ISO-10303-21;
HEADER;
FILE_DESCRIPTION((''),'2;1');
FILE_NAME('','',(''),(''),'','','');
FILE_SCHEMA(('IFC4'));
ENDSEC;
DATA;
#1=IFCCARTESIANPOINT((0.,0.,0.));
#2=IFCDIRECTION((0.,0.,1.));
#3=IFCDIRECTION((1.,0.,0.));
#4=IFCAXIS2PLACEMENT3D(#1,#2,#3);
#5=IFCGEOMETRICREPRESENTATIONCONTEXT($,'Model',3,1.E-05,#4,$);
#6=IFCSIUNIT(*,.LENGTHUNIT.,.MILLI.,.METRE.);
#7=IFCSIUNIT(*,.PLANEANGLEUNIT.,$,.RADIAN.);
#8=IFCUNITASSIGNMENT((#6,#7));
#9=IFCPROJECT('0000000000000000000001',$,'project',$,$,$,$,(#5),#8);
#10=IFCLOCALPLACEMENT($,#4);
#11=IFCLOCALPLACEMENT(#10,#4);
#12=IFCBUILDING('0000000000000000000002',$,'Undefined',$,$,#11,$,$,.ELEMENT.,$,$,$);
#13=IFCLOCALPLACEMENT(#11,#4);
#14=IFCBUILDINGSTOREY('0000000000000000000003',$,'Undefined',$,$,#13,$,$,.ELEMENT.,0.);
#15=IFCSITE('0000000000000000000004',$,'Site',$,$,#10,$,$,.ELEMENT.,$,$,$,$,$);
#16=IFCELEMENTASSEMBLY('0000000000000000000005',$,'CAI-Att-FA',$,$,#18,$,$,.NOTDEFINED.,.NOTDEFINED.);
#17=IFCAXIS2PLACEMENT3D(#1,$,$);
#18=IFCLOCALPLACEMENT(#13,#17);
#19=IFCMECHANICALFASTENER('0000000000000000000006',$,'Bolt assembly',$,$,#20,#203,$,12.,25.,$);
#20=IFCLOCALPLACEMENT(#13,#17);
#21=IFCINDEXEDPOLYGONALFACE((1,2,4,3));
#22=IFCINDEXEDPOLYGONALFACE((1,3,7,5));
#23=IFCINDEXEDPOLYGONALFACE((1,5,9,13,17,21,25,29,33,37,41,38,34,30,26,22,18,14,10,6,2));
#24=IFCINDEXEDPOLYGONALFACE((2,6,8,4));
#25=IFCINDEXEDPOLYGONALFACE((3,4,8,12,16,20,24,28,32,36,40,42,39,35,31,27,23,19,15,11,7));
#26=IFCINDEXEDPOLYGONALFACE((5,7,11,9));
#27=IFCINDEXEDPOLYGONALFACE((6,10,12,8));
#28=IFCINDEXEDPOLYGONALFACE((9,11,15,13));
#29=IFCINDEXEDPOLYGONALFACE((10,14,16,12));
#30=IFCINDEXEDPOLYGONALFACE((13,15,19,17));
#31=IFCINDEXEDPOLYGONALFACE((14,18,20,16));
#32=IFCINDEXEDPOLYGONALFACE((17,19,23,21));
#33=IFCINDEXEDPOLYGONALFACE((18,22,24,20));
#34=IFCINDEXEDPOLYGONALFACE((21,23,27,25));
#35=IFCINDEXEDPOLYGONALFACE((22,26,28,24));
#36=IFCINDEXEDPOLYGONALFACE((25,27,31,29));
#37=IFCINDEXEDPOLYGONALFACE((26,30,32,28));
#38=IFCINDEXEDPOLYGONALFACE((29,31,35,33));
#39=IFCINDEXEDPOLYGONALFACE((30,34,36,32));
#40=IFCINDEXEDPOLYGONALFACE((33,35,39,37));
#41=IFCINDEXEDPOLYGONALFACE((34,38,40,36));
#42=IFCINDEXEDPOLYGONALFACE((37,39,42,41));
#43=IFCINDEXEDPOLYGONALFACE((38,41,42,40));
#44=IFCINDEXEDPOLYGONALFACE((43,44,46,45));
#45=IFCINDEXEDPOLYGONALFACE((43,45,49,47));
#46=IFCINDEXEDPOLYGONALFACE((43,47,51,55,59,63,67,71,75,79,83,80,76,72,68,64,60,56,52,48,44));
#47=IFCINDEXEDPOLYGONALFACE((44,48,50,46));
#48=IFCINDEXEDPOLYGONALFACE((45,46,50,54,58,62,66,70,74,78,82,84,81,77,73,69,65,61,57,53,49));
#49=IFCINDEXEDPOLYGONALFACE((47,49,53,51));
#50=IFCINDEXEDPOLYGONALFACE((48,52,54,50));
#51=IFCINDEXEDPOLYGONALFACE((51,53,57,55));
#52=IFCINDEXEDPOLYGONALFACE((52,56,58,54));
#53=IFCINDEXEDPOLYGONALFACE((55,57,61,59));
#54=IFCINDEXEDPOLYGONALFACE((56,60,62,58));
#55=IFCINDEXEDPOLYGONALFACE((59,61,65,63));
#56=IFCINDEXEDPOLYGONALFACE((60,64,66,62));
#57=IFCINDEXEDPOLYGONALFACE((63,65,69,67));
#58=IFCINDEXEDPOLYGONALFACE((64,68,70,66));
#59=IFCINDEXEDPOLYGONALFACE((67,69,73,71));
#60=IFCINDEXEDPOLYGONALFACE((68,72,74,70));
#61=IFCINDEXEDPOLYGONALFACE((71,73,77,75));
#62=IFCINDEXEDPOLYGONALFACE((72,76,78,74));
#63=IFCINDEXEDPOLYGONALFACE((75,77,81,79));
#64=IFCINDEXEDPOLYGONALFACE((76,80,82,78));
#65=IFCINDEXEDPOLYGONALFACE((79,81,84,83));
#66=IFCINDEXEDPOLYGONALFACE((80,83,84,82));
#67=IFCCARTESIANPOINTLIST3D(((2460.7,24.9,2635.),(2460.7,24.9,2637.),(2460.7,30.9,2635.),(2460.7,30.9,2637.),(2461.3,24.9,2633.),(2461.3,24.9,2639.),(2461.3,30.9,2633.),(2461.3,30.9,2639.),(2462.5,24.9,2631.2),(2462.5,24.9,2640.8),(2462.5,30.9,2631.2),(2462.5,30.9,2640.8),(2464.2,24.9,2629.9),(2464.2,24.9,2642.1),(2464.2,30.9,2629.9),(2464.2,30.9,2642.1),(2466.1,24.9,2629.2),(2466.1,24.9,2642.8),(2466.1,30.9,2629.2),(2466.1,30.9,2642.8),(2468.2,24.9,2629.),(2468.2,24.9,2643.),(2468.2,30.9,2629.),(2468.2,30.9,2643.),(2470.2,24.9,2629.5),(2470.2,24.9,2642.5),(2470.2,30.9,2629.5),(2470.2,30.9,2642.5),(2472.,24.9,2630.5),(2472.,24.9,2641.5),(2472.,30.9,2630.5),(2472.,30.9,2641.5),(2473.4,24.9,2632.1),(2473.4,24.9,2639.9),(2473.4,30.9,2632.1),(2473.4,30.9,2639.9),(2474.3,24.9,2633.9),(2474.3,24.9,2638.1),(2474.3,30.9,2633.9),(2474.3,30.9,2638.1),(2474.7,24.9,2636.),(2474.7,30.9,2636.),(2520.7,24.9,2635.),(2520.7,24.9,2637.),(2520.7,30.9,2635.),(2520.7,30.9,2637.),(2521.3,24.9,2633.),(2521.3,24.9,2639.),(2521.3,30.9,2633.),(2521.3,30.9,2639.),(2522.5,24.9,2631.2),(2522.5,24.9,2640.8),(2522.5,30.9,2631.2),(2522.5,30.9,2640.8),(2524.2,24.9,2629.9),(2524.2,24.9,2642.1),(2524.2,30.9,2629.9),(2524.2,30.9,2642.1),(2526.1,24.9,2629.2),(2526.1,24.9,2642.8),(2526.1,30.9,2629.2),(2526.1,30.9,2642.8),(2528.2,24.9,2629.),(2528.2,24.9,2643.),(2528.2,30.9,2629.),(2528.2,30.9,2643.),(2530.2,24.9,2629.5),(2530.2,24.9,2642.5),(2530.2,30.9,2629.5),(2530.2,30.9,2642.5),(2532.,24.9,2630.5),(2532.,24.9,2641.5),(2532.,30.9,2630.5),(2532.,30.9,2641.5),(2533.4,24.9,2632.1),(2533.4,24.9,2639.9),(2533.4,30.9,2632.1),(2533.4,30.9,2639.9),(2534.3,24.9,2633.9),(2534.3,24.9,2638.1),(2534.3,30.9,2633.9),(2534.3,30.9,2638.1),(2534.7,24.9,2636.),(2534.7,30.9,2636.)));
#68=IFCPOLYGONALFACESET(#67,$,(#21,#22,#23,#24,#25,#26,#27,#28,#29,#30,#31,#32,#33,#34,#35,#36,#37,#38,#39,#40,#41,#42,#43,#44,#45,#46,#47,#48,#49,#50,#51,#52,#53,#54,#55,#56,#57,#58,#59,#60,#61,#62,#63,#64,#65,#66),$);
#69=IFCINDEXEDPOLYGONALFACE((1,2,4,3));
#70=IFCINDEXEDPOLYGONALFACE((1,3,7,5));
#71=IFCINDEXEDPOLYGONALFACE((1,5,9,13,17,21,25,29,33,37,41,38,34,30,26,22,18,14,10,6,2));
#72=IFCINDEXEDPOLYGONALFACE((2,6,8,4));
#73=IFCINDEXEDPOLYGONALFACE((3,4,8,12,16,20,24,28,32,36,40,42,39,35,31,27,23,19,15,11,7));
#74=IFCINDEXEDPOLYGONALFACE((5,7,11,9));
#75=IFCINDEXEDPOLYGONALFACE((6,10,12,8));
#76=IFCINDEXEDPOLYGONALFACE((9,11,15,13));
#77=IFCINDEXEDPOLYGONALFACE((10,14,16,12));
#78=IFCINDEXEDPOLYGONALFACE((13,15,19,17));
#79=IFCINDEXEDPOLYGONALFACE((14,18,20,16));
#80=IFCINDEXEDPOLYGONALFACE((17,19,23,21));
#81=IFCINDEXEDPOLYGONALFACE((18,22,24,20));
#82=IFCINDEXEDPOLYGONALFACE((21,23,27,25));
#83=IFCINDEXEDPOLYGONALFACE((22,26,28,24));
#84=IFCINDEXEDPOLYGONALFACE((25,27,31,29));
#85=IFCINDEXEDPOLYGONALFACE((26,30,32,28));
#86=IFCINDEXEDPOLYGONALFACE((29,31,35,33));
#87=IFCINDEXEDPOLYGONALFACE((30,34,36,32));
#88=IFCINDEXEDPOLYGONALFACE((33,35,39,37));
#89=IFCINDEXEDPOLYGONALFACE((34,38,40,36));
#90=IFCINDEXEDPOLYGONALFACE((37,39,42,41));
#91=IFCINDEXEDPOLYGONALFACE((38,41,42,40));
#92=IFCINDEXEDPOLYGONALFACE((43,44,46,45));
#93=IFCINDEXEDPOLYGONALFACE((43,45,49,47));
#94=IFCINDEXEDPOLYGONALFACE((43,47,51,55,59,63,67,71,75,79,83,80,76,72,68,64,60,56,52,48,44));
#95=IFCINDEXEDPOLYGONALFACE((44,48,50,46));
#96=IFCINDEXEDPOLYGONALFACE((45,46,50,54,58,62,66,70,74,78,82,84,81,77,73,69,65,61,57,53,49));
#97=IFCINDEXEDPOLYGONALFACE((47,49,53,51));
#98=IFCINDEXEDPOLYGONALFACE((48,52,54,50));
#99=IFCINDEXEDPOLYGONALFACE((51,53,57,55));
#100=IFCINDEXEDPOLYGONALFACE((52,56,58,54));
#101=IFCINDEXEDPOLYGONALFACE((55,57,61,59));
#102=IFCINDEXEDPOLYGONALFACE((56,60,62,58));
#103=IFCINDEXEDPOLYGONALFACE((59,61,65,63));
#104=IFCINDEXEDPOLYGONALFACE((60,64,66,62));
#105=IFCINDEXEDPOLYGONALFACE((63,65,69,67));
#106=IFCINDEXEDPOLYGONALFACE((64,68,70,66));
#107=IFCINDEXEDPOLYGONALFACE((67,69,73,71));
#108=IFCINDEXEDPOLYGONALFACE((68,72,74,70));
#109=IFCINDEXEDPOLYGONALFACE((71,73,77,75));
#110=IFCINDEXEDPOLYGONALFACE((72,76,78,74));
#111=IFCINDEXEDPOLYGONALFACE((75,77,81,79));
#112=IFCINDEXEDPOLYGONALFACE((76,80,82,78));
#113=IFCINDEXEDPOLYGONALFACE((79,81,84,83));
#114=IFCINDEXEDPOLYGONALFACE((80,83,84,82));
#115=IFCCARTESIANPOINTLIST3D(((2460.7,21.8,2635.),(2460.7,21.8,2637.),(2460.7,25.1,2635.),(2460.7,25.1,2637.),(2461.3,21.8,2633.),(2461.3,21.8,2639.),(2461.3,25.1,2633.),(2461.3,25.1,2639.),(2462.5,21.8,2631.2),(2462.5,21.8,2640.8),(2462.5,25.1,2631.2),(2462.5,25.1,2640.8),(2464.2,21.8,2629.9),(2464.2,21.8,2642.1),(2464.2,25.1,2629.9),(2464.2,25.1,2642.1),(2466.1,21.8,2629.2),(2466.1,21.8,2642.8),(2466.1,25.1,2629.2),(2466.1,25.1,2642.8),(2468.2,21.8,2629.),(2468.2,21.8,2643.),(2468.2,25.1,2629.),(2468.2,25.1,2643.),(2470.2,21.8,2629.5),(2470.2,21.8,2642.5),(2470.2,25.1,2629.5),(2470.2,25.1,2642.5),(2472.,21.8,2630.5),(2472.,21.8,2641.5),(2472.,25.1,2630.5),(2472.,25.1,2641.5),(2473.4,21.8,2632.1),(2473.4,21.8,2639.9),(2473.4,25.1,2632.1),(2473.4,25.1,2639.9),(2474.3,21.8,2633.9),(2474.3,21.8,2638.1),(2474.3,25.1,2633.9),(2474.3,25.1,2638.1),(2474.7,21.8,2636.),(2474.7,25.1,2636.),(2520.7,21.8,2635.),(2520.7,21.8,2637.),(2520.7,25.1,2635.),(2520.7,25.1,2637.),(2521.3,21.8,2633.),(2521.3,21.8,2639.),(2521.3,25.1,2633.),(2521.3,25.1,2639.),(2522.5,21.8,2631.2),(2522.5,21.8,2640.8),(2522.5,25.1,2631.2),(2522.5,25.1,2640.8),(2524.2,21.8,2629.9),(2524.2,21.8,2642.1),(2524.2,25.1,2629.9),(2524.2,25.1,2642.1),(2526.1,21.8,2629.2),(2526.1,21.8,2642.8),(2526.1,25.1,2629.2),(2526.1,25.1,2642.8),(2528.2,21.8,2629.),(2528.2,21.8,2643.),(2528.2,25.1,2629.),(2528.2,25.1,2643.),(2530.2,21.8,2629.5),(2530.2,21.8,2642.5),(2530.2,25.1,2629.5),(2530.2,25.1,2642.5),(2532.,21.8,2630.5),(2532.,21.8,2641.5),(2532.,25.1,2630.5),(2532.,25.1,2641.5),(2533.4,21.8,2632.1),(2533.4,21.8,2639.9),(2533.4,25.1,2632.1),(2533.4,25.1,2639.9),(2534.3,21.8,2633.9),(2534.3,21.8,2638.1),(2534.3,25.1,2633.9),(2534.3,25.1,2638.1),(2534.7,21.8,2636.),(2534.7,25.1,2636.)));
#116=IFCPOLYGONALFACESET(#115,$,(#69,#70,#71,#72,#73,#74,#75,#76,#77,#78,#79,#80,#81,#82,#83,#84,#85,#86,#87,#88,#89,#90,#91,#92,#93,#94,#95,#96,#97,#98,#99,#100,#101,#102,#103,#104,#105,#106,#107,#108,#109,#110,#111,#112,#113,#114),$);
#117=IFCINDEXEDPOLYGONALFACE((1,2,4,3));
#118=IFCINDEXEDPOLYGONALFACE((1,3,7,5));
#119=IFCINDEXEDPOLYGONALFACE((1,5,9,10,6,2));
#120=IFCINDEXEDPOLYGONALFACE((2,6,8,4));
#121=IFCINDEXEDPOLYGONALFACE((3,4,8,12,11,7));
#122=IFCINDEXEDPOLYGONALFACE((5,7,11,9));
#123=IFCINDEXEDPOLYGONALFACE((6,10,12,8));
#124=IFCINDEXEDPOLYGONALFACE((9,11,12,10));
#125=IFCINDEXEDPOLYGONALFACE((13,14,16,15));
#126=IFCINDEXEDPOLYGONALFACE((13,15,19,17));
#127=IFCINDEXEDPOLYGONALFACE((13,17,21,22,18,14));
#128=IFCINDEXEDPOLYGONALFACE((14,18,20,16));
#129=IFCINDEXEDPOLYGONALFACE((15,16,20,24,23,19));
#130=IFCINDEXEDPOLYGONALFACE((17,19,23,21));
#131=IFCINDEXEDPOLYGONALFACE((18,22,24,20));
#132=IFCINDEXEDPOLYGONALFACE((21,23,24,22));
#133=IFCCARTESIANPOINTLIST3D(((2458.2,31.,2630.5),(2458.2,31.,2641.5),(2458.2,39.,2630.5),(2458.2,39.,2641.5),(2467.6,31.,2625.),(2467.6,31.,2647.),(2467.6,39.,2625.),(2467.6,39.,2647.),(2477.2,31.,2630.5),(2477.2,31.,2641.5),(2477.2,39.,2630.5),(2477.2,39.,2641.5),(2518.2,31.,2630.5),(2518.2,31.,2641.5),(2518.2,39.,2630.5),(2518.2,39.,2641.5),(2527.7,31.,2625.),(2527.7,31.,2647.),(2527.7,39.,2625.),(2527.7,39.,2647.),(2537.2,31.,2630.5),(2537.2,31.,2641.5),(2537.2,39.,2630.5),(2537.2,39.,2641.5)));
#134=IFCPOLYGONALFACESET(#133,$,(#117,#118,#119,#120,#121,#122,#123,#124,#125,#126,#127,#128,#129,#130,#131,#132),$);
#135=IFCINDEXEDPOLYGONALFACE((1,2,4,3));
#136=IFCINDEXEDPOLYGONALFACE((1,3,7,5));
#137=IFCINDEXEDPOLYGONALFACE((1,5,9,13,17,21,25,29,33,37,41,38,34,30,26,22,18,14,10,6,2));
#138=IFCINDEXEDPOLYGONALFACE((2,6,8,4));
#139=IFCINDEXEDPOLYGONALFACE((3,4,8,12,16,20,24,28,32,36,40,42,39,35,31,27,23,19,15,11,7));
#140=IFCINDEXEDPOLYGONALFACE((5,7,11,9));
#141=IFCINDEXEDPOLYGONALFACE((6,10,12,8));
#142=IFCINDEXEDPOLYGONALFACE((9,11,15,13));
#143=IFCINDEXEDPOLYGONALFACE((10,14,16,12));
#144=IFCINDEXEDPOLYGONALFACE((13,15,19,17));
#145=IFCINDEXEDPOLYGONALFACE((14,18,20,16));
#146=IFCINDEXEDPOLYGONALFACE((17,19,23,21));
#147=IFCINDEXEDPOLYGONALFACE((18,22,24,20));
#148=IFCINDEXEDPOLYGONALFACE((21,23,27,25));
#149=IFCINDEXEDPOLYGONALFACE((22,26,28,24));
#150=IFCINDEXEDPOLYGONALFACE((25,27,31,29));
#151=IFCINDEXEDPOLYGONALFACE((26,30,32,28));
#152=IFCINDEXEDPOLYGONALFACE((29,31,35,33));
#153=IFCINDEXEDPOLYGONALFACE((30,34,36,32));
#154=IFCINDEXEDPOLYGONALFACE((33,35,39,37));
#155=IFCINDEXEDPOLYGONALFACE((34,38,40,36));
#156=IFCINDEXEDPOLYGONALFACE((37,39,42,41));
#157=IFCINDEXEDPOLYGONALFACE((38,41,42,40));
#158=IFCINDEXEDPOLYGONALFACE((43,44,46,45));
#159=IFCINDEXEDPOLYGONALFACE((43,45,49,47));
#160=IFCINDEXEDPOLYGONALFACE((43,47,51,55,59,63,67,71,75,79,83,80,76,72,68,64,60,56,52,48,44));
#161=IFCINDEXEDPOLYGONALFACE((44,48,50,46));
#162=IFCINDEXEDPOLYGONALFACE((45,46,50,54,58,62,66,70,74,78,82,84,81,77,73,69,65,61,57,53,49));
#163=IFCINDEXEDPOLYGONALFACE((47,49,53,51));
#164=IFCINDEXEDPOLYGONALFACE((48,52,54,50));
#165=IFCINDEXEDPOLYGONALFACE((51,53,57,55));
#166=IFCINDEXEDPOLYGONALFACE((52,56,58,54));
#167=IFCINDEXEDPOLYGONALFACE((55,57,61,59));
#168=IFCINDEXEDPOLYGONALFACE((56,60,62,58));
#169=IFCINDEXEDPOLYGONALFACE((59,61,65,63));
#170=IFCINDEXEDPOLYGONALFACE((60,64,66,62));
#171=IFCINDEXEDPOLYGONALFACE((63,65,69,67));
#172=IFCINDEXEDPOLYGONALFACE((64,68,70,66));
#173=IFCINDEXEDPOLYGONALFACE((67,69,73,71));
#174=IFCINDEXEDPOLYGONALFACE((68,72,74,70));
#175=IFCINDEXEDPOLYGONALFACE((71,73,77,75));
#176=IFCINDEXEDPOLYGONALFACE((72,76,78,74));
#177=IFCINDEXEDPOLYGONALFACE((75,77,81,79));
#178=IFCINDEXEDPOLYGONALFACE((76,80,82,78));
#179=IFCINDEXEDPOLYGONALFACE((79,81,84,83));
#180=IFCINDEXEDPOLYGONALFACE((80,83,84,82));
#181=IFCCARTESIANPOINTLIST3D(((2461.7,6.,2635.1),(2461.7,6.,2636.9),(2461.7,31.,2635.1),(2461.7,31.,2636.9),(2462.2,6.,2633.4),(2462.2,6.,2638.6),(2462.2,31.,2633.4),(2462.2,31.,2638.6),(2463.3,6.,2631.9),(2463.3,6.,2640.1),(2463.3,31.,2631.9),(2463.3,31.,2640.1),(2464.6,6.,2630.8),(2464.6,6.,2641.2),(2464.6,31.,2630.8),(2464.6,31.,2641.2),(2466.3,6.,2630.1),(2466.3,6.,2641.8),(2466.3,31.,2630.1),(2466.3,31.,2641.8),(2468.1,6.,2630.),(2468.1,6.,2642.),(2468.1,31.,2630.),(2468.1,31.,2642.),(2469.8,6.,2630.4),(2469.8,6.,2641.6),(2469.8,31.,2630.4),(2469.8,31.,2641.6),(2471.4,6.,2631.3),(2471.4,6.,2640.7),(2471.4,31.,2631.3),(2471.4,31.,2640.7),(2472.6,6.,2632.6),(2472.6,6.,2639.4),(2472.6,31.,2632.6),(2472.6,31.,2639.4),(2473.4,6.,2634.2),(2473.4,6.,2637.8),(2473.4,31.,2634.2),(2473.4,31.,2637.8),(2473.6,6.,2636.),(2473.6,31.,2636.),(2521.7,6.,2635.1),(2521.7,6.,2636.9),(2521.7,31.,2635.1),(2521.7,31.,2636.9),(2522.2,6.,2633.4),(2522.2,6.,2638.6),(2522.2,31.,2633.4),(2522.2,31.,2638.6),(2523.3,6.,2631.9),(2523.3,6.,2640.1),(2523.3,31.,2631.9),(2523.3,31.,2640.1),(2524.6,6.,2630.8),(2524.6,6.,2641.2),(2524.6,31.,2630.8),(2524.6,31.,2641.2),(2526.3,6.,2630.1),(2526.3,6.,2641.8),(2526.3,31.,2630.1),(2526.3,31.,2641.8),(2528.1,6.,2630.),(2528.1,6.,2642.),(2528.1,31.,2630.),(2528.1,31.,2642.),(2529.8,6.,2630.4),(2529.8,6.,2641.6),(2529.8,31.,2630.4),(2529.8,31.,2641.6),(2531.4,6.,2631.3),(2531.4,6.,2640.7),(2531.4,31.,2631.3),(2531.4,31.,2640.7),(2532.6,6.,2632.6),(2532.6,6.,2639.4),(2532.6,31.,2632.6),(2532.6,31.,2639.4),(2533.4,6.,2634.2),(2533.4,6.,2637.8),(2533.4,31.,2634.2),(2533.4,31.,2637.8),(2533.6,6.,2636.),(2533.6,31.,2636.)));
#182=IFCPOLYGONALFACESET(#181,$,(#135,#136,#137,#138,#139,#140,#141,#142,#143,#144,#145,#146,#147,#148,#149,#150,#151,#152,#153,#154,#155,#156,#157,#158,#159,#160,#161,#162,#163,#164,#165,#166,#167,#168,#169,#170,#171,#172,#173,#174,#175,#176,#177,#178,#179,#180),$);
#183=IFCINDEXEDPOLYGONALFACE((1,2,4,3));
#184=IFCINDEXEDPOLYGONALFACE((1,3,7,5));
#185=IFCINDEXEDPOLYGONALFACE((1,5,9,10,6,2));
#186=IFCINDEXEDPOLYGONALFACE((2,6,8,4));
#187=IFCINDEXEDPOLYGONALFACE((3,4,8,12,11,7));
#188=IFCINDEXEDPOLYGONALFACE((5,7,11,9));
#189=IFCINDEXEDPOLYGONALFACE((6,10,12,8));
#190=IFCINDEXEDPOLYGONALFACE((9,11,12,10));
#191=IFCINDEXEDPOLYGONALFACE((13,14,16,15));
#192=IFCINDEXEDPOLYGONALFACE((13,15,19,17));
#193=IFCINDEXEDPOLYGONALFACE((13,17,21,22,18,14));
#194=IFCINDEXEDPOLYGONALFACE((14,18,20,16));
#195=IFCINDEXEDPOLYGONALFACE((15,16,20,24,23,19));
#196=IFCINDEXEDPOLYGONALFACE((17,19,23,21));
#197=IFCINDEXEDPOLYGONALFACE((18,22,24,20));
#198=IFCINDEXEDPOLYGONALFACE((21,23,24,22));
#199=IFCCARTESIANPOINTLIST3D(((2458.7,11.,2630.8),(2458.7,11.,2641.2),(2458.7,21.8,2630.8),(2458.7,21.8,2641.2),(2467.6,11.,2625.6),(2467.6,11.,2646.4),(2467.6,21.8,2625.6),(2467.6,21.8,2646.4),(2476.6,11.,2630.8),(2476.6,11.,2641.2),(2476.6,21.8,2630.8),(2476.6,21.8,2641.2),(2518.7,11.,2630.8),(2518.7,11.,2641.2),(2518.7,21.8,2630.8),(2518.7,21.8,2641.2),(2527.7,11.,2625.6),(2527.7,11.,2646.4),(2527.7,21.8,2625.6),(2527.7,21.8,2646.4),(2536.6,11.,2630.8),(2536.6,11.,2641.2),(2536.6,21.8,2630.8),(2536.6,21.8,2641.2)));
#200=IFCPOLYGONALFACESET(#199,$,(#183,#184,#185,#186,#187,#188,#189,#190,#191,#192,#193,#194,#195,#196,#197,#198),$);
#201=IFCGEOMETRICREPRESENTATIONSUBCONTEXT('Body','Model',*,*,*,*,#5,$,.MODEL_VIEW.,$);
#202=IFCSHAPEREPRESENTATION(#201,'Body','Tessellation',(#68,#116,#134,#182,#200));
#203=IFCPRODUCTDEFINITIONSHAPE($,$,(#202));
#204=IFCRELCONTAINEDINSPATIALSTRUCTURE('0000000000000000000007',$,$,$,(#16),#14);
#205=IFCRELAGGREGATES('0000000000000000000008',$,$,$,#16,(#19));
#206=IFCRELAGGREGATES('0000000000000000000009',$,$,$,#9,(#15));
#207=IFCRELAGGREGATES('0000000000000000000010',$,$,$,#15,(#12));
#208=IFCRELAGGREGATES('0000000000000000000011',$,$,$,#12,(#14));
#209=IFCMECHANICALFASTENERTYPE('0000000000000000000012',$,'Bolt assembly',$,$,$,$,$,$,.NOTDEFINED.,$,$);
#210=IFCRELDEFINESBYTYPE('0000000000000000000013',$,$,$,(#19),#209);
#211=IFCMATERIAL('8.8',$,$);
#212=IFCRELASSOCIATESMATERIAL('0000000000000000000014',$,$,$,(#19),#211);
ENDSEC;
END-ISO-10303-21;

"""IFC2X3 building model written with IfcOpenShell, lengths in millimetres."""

from ifc_helpers import new_model, si_unit, frame, origin_with_axes, origin_2d_with_axis, place, context, subcontext, project, spatial, polyline, circle, outline, extrude, source, transform, mapped, material, type_object, element, aggregate, save


model = new_model("IFC2X3")

# Units and contexts
model_context = context("Model", 3, precision=1e-05, world=origin_with_axes())
body_context = subcontext(model_context, "Body", "Model", "MODEL_VIEW")
ifc_project = project(units=[si_unit("LENGTHUNIT", "METRE", prefix="MILLI"), si_unit("PLANEANGLEUNIT", "RADIAN")], contexts=[model_context])

# Site, building, storey
site_placement = place(None, origin_with_axes())
site = spatial("IfcSite", under=ifc_project, at=site_placement, Name="Site", CompositionType="ELEMENT")
building_placement = place(site_placement, origin_with_axes())
building = spatial("IfcBuilding", under=site, at=building_placement, Name="Undefined", CompositionType="ELEMENT")
storey_placement = place(building_placement, origin_with_axes())
storey = spatial("IfcBuildingStorey", under=building, at=storey_placement, Name="Undefined", CompositionType="ELEMENT", Elevation=0.0)

# Shared definitions
mechanical_fastener_type = type_object("IfcMechanicalFastenerType", Name="Bolt assembly")

# Element assembly, mechanical fastener
assembly_1_placement = place(storey_placement, origin_with_axes())
assembly_1 = element("IfcElementAssembly", 1, at=assembly_1_placement, inside=storey, Name="CAI-Att-FA", AssemblyPlace="NOTDEFINED", PredefinedType="NOTDEFINED")
ifc_material_1 = material(Name="8.8")
shared_shape_1 = source(origin_with_axes(), body_context, "Body", "SweptSolid", [
    extrude(circle(Radius=7.0, at=origin_2d_with_axis()), frame((0.0, -5.9, 0.0), z_axis=(0.0, 1.0, 0.0), x_axis=(1.0, 0.0, 0.0)), (0.0, 0.0, 1.0), 6.0),
    extrude(circle(Radius=7.0, at=origin_2d_with_axis()), frame((0.0, -0.1, 0.0), z_axis=(0.0, 1.0, 0.0), x_axis=(1.0, 0.0, 0.0)), (0.0, 0.0, 1.0), 3.3),
    extrude(outline(polyline([(9.5, -5.5), (9.5, 5.5), (0.0, 11.0), (-9.5, 5.5), (-9.5, -5.5), (0.0, -11.0), (9.5, -5.5)])), frame((0.0, -14.0, 0.0), z_axis=(0.0, 1.0, 0.0), x_axis=(1.0, 0.0, 0.0)), (0.0, 0.0, 1.0), 8.0),
    extrude(circle(Radius=6.0, at=origin_2d_with_axis()), frame((0.0, -6.0, 0.0), z_axis=(0.0, 1.0, 0.0), x_axis=(1.0, 0.0, 0.0)), (0.0, 0.0, 1.0), 25.0),
    extrude(outline(polyline([(9.0, -5.2), (9.0, 5.2), (0.0, 10.4), (-9.0, 5.2), (-9.0, -5.2), (0.0, -10.4), (9.0, -5.2)])), frame((0.0, 3.2, 0.0), z_axis=(0.0, 1.0, 0.0), x_axis=(1.0, 0.0, 0.0)), (0.0, 0.0, 1.0), 10.8),
])
mechanical_fastener_1_placement = place(assembly_1_placement, frame((2467.7, 25.0, 2636.0), z_axis=(0.0, 0.0, -1.0), x_axis=(1.0, 0.0, 0.0)))
mechanical_fastener_1 = element("IfcMechanicalFastener", 2, at=mechanical_fastener_1_placement, type_object=mechanical_fastener_type, material=ifc_material_1, Name="Bolt assembly", NominalDiameter=12.0, NominalLength=25.0, context=body_context, shape_type="MappedRepresentation", body=[
    mapped(shared_shape_1, transform((0.0, 0.0, 0.0))),
    mapped(shared_shape_1, transform((60.0, 0.0, 0.0))),
])
aggregate(assembly_1, [mechanical_fastener_1])

save(model, "model.ifc")
